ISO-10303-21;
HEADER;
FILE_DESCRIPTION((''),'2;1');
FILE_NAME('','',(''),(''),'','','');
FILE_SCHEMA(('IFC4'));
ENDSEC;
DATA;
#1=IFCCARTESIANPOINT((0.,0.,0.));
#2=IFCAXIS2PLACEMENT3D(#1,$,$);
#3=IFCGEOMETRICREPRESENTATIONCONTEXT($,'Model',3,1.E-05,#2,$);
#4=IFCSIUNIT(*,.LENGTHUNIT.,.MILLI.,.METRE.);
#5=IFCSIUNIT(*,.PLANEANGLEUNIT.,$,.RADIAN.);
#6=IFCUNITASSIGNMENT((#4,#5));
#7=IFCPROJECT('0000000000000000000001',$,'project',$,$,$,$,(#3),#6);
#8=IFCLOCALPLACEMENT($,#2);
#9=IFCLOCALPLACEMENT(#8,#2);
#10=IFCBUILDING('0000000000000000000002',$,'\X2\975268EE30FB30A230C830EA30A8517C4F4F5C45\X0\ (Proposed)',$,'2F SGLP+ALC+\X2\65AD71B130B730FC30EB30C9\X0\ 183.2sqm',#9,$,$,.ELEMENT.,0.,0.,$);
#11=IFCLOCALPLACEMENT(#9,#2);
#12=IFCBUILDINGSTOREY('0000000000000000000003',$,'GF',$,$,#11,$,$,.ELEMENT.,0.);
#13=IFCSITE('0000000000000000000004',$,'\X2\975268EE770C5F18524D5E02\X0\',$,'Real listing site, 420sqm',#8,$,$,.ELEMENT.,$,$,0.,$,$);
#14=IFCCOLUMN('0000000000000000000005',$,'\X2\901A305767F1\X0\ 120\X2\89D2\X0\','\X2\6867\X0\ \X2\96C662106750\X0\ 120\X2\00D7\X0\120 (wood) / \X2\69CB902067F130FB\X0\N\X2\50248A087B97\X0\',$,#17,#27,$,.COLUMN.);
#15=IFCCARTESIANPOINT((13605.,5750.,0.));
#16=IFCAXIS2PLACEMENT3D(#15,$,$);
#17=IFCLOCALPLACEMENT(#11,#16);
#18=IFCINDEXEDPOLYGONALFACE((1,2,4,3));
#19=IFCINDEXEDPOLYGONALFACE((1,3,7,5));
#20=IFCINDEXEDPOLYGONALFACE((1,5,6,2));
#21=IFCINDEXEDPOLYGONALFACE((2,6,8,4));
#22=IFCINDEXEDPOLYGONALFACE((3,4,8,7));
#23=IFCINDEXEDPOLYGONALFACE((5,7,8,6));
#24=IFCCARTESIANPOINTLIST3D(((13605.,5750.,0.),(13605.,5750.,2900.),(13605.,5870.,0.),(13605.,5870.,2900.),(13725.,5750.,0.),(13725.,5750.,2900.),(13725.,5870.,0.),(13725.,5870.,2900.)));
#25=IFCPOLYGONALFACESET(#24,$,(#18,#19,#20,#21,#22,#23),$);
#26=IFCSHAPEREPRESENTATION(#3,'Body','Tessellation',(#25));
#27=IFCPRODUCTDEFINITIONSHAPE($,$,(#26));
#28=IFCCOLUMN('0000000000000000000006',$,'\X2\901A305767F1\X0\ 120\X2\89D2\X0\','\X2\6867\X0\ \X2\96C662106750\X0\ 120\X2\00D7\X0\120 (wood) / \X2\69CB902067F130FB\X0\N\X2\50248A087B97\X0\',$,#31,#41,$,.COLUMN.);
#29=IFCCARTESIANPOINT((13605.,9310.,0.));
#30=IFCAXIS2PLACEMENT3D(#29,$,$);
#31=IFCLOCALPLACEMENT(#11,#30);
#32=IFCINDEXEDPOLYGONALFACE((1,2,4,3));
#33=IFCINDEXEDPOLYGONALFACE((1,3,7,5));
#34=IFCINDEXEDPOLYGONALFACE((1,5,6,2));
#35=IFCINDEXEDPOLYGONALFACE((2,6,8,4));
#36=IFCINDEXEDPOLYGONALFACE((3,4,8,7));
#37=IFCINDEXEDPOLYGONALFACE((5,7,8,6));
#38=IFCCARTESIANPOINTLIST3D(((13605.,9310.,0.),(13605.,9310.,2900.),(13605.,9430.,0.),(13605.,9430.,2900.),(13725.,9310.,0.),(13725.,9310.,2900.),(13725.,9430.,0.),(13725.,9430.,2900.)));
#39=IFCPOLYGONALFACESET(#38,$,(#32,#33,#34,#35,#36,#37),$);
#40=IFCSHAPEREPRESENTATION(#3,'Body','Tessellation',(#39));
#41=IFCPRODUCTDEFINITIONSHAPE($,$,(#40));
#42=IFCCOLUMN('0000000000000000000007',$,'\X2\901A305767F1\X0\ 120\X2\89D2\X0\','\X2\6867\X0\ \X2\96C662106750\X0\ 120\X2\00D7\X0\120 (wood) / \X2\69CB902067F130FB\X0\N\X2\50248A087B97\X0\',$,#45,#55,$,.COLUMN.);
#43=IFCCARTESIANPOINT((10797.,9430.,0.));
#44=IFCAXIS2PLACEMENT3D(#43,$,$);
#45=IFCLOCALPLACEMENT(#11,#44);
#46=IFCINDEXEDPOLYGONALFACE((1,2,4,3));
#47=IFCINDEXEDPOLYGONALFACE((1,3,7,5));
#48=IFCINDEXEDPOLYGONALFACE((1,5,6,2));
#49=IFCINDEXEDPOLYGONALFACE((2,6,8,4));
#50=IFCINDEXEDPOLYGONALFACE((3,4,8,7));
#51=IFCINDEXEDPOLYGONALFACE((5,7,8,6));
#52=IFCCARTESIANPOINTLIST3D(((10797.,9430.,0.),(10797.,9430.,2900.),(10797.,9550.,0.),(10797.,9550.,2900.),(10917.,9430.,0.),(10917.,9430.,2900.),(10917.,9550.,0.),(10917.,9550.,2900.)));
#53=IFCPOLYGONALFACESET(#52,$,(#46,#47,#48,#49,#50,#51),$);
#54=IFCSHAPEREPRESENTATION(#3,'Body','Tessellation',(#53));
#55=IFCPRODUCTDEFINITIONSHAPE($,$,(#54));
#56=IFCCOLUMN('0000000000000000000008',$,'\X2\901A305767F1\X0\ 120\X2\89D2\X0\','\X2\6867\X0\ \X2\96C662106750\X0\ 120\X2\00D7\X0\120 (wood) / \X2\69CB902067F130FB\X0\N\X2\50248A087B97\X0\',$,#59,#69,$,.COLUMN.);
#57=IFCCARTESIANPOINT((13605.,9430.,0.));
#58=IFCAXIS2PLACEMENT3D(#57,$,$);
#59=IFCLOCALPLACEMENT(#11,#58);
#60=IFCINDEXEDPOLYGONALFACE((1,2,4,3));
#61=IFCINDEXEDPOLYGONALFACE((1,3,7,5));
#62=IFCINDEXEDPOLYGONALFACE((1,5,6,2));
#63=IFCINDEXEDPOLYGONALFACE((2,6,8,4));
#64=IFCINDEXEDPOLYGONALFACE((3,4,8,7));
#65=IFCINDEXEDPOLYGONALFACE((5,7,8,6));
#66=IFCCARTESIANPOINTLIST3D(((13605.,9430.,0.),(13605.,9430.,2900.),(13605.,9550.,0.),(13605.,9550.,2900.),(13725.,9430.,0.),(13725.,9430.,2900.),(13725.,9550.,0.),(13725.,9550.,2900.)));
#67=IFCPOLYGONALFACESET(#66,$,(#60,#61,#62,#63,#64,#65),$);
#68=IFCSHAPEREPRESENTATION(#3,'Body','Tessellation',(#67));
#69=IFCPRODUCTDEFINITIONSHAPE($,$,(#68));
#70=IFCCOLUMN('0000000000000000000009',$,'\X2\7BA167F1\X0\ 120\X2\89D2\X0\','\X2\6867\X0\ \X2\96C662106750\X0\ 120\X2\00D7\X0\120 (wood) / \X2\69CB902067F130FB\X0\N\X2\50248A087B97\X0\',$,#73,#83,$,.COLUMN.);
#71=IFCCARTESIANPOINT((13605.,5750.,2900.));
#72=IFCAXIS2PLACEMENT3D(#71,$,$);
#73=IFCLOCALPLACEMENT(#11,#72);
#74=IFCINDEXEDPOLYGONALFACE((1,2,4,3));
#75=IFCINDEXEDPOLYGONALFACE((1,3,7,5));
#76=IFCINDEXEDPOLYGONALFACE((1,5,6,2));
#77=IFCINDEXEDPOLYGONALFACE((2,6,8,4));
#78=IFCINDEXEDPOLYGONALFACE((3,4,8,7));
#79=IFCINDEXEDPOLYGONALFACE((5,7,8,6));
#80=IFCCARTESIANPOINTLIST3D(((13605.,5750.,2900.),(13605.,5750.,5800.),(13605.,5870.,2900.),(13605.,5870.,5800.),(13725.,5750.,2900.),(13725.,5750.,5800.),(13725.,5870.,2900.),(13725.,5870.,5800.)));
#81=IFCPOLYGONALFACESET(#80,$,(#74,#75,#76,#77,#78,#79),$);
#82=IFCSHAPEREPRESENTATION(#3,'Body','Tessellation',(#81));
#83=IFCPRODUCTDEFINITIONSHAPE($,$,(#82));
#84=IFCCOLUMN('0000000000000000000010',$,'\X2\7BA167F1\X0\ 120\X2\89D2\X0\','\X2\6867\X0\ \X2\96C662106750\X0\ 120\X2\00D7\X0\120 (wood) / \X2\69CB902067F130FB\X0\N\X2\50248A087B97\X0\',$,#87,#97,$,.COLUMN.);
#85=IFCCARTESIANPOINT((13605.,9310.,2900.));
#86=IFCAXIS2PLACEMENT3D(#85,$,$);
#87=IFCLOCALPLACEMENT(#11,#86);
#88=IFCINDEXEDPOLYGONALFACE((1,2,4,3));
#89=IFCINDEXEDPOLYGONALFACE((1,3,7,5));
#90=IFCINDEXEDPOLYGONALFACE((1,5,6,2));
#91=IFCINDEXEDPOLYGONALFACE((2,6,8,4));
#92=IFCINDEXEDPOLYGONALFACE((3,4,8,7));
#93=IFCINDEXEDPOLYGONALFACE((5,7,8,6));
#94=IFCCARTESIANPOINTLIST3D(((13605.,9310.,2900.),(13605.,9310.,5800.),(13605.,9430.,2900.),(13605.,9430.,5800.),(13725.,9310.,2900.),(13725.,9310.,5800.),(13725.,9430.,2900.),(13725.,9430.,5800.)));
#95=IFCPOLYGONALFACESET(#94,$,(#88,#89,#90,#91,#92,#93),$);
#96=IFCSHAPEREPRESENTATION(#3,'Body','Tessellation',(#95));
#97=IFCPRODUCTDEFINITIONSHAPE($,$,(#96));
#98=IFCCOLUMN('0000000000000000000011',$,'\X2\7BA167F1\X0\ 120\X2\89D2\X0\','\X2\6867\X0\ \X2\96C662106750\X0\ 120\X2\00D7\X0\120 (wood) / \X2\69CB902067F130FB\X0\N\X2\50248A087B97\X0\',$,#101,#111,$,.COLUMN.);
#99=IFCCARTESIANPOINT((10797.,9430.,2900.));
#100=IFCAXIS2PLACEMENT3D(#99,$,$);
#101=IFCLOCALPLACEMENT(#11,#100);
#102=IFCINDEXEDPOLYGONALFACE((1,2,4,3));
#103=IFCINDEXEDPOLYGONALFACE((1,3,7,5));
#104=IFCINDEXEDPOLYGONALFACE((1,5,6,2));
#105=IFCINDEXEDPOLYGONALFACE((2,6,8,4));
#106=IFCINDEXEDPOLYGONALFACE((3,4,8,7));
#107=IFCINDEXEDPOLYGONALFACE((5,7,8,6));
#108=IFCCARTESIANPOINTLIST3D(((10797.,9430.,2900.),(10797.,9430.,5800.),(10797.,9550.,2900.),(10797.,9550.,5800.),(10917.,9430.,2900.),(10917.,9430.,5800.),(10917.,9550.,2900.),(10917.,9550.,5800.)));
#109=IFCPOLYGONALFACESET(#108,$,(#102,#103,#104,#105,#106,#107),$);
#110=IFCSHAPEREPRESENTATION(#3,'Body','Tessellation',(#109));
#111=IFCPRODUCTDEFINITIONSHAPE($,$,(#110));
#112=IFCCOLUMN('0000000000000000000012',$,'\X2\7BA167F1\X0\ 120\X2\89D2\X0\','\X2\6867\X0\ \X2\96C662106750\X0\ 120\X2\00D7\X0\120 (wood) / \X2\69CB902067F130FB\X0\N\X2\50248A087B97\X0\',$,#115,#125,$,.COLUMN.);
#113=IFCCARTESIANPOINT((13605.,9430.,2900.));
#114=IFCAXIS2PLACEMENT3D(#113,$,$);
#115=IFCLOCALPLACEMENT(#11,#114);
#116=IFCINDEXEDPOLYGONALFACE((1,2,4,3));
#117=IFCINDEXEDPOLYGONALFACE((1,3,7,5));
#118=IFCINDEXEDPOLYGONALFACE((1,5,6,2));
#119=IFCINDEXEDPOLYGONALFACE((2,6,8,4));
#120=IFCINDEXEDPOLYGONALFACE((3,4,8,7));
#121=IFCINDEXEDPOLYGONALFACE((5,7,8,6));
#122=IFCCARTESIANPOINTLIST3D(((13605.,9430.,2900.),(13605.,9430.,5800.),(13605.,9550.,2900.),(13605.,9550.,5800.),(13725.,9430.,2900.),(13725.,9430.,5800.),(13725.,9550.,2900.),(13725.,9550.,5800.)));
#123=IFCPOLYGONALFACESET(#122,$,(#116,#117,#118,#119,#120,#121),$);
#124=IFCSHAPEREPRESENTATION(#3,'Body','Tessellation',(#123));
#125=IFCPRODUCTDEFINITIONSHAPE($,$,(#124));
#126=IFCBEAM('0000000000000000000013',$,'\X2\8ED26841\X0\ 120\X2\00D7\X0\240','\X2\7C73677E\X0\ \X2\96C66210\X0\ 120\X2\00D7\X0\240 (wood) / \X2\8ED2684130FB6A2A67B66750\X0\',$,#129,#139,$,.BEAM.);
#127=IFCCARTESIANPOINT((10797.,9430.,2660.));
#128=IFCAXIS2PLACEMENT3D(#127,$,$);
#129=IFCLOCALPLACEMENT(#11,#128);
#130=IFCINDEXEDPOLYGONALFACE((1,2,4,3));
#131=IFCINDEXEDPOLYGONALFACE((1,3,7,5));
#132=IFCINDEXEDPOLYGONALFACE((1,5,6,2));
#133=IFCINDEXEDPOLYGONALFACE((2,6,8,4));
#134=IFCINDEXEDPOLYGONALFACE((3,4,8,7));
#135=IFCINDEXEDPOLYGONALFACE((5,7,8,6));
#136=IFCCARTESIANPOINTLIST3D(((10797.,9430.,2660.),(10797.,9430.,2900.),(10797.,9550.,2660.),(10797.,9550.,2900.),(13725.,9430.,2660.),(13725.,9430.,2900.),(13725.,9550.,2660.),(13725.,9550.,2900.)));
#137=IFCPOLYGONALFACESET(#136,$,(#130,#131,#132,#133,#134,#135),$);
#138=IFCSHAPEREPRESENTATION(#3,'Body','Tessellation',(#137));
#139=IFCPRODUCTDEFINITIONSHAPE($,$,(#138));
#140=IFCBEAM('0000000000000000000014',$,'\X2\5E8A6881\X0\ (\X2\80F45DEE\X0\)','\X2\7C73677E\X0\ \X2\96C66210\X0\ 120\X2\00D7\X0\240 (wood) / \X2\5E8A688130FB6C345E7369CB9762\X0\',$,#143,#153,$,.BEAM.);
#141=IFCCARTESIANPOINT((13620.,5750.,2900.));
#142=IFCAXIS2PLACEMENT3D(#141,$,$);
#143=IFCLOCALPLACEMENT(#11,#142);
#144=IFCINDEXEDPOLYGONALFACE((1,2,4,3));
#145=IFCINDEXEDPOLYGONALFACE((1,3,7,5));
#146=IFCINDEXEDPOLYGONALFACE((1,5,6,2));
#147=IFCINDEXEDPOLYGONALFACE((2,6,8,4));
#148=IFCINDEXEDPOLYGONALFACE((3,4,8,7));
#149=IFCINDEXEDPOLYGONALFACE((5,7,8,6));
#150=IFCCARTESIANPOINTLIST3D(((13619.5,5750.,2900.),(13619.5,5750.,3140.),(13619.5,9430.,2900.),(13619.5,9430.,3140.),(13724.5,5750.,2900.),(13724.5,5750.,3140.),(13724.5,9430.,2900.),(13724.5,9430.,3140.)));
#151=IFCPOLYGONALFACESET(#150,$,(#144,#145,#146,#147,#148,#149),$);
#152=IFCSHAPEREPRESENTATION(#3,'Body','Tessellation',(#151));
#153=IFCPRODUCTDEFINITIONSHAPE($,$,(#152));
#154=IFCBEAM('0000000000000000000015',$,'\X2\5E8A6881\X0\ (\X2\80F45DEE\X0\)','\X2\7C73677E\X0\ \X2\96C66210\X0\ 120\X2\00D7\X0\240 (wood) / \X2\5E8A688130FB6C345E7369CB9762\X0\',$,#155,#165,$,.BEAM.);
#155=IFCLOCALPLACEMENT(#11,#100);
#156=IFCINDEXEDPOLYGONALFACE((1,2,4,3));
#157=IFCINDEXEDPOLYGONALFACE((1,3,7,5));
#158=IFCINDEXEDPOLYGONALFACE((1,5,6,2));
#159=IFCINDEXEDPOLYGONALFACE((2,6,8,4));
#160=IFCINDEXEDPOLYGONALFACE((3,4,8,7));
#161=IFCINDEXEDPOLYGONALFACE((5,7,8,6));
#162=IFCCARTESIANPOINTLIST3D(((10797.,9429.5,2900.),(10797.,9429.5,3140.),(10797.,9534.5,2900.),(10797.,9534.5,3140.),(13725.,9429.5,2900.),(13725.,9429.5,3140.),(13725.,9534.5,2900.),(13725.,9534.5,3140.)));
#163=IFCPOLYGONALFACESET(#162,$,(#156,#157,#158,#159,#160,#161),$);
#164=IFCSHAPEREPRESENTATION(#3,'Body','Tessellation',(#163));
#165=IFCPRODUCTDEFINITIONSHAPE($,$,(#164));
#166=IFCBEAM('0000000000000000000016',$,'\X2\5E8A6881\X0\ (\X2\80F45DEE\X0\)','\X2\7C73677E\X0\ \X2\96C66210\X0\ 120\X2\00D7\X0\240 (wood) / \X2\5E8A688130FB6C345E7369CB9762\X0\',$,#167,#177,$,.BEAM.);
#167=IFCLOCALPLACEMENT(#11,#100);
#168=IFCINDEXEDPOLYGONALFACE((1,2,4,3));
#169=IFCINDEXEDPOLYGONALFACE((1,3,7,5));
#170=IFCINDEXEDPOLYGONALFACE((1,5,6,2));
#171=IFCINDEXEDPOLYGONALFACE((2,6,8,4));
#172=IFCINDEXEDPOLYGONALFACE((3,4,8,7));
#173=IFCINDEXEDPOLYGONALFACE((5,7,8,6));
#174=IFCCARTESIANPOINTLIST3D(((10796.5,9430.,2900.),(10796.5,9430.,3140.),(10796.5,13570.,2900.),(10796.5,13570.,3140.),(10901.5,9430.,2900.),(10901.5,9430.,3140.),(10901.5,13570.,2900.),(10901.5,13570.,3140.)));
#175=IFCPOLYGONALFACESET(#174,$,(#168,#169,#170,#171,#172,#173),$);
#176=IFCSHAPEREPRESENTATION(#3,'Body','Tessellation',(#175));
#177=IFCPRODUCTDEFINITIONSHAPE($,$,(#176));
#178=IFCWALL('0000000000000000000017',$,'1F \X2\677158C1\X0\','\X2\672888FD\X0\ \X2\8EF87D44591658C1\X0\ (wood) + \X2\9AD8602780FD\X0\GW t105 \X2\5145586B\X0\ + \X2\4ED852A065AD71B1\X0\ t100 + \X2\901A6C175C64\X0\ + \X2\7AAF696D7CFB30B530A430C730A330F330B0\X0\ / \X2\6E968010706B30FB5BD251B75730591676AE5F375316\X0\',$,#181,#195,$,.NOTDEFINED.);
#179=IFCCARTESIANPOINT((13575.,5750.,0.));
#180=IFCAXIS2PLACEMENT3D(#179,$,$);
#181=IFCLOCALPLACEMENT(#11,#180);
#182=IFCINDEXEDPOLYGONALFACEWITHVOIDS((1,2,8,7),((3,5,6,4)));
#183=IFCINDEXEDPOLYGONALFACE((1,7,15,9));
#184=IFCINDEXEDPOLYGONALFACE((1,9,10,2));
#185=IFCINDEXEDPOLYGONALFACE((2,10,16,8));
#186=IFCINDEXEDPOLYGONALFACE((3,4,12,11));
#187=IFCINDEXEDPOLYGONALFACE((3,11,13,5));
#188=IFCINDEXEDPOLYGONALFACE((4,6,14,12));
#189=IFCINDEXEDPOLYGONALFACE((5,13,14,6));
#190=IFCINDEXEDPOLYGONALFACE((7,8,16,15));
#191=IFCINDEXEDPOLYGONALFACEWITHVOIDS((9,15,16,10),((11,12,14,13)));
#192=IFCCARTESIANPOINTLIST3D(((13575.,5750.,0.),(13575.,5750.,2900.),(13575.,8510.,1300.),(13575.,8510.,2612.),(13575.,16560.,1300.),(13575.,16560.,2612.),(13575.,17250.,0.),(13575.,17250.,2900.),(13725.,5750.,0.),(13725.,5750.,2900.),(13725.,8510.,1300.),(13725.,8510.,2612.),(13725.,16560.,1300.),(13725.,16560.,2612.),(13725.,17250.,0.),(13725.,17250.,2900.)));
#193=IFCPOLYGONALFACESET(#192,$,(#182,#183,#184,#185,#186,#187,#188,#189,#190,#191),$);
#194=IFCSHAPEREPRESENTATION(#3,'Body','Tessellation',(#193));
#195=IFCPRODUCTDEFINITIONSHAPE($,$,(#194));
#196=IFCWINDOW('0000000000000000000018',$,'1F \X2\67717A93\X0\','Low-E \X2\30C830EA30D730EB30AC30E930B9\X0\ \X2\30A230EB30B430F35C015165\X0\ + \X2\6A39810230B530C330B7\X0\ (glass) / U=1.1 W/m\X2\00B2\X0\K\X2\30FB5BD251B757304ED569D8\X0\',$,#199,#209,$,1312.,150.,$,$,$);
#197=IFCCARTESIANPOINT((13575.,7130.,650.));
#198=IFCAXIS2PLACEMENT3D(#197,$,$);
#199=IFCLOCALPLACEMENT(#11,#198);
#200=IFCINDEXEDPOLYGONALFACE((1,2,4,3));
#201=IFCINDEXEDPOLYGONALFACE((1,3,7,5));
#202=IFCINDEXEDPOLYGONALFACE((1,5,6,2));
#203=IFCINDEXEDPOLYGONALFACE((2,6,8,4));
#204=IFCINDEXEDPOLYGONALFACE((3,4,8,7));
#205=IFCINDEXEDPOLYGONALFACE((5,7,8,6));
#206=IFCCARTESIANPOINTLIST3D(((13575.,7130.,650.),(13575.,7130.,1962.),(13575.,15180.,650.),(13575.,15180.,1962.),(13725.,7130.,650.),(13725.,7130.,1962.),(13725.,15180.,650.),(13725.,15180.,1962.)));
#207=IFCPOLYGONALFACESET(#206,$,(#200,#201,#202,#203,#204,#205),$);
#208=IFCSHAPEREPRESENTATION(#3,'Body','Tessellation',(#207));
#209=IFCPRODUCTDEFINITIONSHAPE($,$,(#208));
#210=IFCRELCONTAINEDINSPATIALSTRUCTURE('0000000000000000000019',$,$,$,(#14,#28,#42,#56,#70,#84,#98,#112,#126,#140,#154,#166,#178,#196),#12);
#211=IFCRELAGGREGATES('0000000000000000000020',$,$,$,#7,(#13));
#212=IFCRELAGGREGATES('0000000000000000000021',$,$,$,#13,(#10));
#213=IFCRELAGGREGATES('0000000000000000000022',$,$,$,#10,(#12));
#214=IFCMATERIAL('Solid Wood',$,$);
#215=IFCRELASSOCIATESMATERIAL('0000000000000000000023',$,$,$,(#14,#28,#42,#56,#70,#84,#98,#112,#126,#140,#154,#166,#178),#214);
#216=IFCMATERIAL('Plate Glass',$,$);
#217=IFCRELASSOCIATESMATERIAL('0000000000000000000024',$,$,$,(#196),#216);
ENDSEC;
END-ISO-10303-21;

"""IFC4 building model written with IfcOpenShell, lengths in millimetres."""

from ifc_helpers import new_model, si_unit, frame, frame_2d, origin, place, context, project, spatial, rectangle, extrude, material, element, fill, save


model = new_model("IFC4")

# Units and contexts
model_context = context("Model", 3, precision=1e-05, world=origin())
ifc_project = project(units=[si_unit("LENGTHUNIT", "METRE", prefix="MILLI"), si_unit("PLANEANGLEUNIT", "RADIAN")], contexts=[model_context])

# Site, building, storey
site_placement = place(None, origin())
site = spatial("IfcSite", under=ifc_project, at=site_placement, Name="青森県弘前市", ObjectType="Real listing site, 420sqm", CompositionType="ELEMENT", RefElevation=0.0)
building_placement = place(site_placement, origin())
building = spatial("IfcBuilding", under=site, at=building_placement, Name="青森・アトリエ兼住居 (Proposed)", ObjectType="2F SGLP+ALC+断熱シールド 183.2sqm", CompositionType="ELEMENT", ElevationOfRefHeight=0.0, ElevationOfTerrain=0.0)
storey_placement = place(building_placement, origin())
storey = spatial("IfcBuildingStorey", under=building, at=storey_placement, Name="GF", CompositionType="ELEMENT", Elevation=0.0)

# Columns
ifc_material_1 = material(Name="Solid Wood")
column_1_placement = place(storey_placement, frame((13605.0, 5750.0, 0.0)))
element("IfcColumn", 1, at=column_1_placement, inside=storey, material=ifc_material_1, Name="通し柱 120角", Description="桧 集成材 120×120 (wood) / 構造柱・N値計算", PredefinedType="COLUMN", context=model_context, shape_type="SweptSolid", body=[
    extrude(rectangle(XDim=120.0, YDim=120.0, at=frame_2d((60.0, 60.0))), frame((13605.0, 5750.0, 0.0)), (0.0, 0.0, 1.0), 2900.0),
])
column_2_placement = place(storey_placement, frame((13605.0, 9310.0, 0.0)))
element("IfcColumn", 2, at=column_2_placement, inside=storey, material=ifc_material_1, Name="通し柱 120角", Description="桧 集成材 120×120 (wood) / 構造柱・N値計算", PredefinedType="COLUMN", context=model_context, shape_type="SweptSolid", body=[
    extrude(rectangle(XDim=120.0, YDim=120.0, at=frame_2d((60.0, 60.0))), frame((13605.0, 9310.0, 0.0)), (0.0, 0.0, 1.0), 2900.0),
])
column_3_placement = place(storey_placement, frame((10797.0, 9430.0, 0.0)))
element("IfcColumn", 3, at=column_3_placement, inside=storey, material=ifc_material_1, Name="通し柱 120角", Description="桧 集成材 120×120 (wood) / 構造柱・N値計算", PredefinedType="COLUMN", context=model_context, shape_type="SweptSolid", body=[
    extrude(rectangle(XDim=120.0, YDim=120.0, at=frame_2d((60.0, 60.0))), frame((10797.0, 9430.0, 0.0)), (0.0, 0.0, 1.0), 2900.0),
])
column_4_placement = place(storey_placement, frame((13605.0, 9430.0, 0.0)))
element("IfcColumn", 4, at=column_4_placement, inside=storey, material=ifc_material_1, Name="通し柱 120角", Description="桧 集成材 120×120 (wood) / 構造柱・N値計算", PredefinedType="COLUMN", context=model_context, shape_type="SweptSolid", body=[
    extrude(rectangle(XDim=120.0, YDim=120.0, at=frame_2d((60.0, 60.0))), frame((13605.0, 9430.0, 0.0)), (0.0, 0.0, 1.0), 2900.0),
])
column_5_placement = place(storey_placement, frame((13605.0, 5750.0, 2900.0)))
element("IfcColumn", 5, at=column_5_placement, inside=storey, material=ifc_material_1, Name="管柱 120角", Description="桧 集成材 120×120 (wood) / 構造柱・N値計算", PredefinedType="COLUMN", context=model_context, shape_type="SweptSolid", body=[
    extrude(rectangle(XDim=120.0, YDim=120.0, at=frame_2d((60.0, 60.0))), frame((13605.0, 5750.0, 2900.0)), (0.0, 0.0, 1.0), 2900.0),
])
column_6_placement = place(storey_placement, frame((13605.0, 9310.0, 2900.0)))
element("IfcColumn", 6, at=column_6_placement, inside=storey, material=ifc_material_1, Name="管柱 120角", Description="桧 集成材 120×120 (wood) / 構造柱・N値計算", PredefinedType="COLUMN", context=model_context, shape_type="SweptSolid", body=[
    extrude(rectangle(XDim=120.0, YDim=120.0, at=frame_2d((60.0, 60.0))), frame((13605.0, 9310.0, 2900.0)), (0.0, 0.0, 1.0), 2900.0),
])
column_7_placement = place(storey_placement, frame((10797.0, 9430.0, 2900.0)))
element("IfcColumn", 7, at=column_7_placement, inside=storey, material=ifc_material_1, Name="管柱 120角", Description="桧 集成材 120×120 (wood) / 構造柱・N値計算", PredefinedType="COLUMN", context=model_context, shape_type="SweptSolid", body=[
    extrude(rectangle(XDim=120.0, YDim=120.0, at=frame_2d((60.0, 60.0))), frame((10797.0, 9430.0, 2900.0)), (0.0, 0.0, 1.0), 2900.0),
])
column_8_placement = place(storey_placement, frame((13605.0, 9430.0, 2900.0)))
element("IfcColumn", 8, at=column_8_placement, inside=storey, material=ifc_material_1, Name="管柱 120角", Description="桧 集成材 120×120 (wood) / 構造柱・N値計算", PredefinedType="COLUMN", context=model_context, shape_type="SweptSolid", body=[
    extrude(rectangle(XDim=120.0, YDim=120.0, at=frame_2d((60.0, 60.0))), frame((13605.0, 9430.0, 2900.0)), (0.0, 0.0, 1.0), 2900.0),
])

# Beams
beam_1_placement = place(storey_placement, frame((10797.0, 9430.0, 2660.0)))
element("IfcBeam", 9, at=beam_1_placement, inside=storey, material=ifc_material_1, Name="軒桁 120×240", Description="米松 集成 120×240 (wood) / 軒桁・横架材", PredefinedType="BEAM", context=model_context, shape_type="SweptSolid", body=[
    extrude(rectangle(XDim=2928.0, YDim=120.0, at=frame_2d((1464.0, 60.0))), frame((10797.0, 9430.0, 2660.0)), (0.0, 0.0, 1.0), 240.0),
])
beam_2_placement = place(storey_placement, frame((13620.0, 5750.0, 2900.0)))
element("IfcBeam", 10, at=beam_2_placement, inside=storey, material=ifc_material_1, Name="床梁 (胴差)", Description="米松 集成 120×240 (wood) / 床梁・水平構面", PredefinedType="BEAM", context=model_context, shape_type="SweptSolid", body=[
    extrude(rectangle(XDim=105.0, YDim=3680.0, at=frame_2d((52.0, 1840.0))), frame((13620.0, 5750.0, 2900.0)), (0.0, 0.0, 1.0), 240.0),
])
beam_3_placement = place(storey_placement, frame((10797.0, 9430.0, 2900.0)))
element("IfcBeam", 11, at=beam_3_placement, inside=storey, material=ifc_material_1, Name="床梁 (胴差)", Description="米松 集成 120×240 (wood) / 床梁・水平構面", PredefinedType="BEAM", context=model_context, shape_type="SweptSolid", body=[
    extrude(rectangle(XDim=2928.0, YDim=105.0, at=frame_2d((1464.0, 52.0))), frame((10797.0, 9430.0, 2900.0)), (0.0, 0.0, 1.0), 240.0),
])
beam_4_placement = place(storey_placement, frame((10797.0, 9430.0, 2900.0)))
element("IfcBeam", 12, at=beam_4_placement, inside=storey, material=ifc_material_1, Name="床梁 (胴差)", Description="米松 集成 120×240 (wood) / 床梁・水平構面", PredefinedType="BEAM", context=model_context, shape_type="SweptSolid", body=[
    extrude(rectangle(XDim=105.0, YDim=4140.0, at=frame_2d((52.0, 2070.0))), frame((10797.0, 9430.0, 2900.0)), (0.0, 0.0, 1.0), 240.0),
])

# Wall, opening, window
wall_1_placement = place(storey_placement, frame((13575.0, 5750.0, 0.0)))
wall_1 = element("IfcWall", 13, at=wall_1_placement, inside=storey, material=ifc_material_1, Name="1F 東壁", Description="木製 軸組外壁 (wood) + 高性能GW t105 充填 + 付加断熱 t100 + 通気層 + 窯業系サイディング / 準耐火・寒冷地外皮強化", PredefinedType="NOTDEFINED", context=model_context, shape_type="SweptSolid", body=[
    extrude(rectangle(XDim=150.0, YDim=11500.0, at=frame_2d((75.0, 5750.0))), frame((13575.0, 5750.0, 0.0)), (0.0, 0.0, 1.0), 2900.0),
])
opening_1_placement = place(storey_placement, frame((13575.0, 7130.0, 650.0)))
opening_1 = element("IfcOpeningElement", 14, at=opening_1_placement, cuts=wall_1, PredefinedType="NOTDEFINED", context=model_context, shape_type="SweptSolid", body=[
    extrude(rectangle(XDim=150.0, YDim=8050.0, at=frame_2d((75.0, 4025.0))), frame((13575.0, 7130.0, 650.0)), (0.0, 0.0, 1.0), 1312.0),
])
ifc_material_2 = material(Name="Plate Glass")
window_1_placement = place(storey_placement, frame((13575.0, 7130.0, 650.0)))
window_1 = element("IfcWindow", 15, at=window_1_placement, inside=storey, material=ifc_material_2, Name="1F 東窓", Description="Low-E トリプルガラス アルゴン封入 + 樹脂サッシ (glass) / U=1.1 W/m²K・寒冷地仕様", OverallHeight=1312.0, OverallWidth=150.0, context=model_context, shape_type="SweptSolid", body=[
    extrude(rectangle(XDim=150.0, YDim=8050.0, at=frame_2d((75.0, 4025.0))), frame((13575.0, 7130.0, 650.0)), (0.0, 0.0, 1.0), 1312.0),
])
fill(opening_1, window_1)

save(model, "model.ifc")
